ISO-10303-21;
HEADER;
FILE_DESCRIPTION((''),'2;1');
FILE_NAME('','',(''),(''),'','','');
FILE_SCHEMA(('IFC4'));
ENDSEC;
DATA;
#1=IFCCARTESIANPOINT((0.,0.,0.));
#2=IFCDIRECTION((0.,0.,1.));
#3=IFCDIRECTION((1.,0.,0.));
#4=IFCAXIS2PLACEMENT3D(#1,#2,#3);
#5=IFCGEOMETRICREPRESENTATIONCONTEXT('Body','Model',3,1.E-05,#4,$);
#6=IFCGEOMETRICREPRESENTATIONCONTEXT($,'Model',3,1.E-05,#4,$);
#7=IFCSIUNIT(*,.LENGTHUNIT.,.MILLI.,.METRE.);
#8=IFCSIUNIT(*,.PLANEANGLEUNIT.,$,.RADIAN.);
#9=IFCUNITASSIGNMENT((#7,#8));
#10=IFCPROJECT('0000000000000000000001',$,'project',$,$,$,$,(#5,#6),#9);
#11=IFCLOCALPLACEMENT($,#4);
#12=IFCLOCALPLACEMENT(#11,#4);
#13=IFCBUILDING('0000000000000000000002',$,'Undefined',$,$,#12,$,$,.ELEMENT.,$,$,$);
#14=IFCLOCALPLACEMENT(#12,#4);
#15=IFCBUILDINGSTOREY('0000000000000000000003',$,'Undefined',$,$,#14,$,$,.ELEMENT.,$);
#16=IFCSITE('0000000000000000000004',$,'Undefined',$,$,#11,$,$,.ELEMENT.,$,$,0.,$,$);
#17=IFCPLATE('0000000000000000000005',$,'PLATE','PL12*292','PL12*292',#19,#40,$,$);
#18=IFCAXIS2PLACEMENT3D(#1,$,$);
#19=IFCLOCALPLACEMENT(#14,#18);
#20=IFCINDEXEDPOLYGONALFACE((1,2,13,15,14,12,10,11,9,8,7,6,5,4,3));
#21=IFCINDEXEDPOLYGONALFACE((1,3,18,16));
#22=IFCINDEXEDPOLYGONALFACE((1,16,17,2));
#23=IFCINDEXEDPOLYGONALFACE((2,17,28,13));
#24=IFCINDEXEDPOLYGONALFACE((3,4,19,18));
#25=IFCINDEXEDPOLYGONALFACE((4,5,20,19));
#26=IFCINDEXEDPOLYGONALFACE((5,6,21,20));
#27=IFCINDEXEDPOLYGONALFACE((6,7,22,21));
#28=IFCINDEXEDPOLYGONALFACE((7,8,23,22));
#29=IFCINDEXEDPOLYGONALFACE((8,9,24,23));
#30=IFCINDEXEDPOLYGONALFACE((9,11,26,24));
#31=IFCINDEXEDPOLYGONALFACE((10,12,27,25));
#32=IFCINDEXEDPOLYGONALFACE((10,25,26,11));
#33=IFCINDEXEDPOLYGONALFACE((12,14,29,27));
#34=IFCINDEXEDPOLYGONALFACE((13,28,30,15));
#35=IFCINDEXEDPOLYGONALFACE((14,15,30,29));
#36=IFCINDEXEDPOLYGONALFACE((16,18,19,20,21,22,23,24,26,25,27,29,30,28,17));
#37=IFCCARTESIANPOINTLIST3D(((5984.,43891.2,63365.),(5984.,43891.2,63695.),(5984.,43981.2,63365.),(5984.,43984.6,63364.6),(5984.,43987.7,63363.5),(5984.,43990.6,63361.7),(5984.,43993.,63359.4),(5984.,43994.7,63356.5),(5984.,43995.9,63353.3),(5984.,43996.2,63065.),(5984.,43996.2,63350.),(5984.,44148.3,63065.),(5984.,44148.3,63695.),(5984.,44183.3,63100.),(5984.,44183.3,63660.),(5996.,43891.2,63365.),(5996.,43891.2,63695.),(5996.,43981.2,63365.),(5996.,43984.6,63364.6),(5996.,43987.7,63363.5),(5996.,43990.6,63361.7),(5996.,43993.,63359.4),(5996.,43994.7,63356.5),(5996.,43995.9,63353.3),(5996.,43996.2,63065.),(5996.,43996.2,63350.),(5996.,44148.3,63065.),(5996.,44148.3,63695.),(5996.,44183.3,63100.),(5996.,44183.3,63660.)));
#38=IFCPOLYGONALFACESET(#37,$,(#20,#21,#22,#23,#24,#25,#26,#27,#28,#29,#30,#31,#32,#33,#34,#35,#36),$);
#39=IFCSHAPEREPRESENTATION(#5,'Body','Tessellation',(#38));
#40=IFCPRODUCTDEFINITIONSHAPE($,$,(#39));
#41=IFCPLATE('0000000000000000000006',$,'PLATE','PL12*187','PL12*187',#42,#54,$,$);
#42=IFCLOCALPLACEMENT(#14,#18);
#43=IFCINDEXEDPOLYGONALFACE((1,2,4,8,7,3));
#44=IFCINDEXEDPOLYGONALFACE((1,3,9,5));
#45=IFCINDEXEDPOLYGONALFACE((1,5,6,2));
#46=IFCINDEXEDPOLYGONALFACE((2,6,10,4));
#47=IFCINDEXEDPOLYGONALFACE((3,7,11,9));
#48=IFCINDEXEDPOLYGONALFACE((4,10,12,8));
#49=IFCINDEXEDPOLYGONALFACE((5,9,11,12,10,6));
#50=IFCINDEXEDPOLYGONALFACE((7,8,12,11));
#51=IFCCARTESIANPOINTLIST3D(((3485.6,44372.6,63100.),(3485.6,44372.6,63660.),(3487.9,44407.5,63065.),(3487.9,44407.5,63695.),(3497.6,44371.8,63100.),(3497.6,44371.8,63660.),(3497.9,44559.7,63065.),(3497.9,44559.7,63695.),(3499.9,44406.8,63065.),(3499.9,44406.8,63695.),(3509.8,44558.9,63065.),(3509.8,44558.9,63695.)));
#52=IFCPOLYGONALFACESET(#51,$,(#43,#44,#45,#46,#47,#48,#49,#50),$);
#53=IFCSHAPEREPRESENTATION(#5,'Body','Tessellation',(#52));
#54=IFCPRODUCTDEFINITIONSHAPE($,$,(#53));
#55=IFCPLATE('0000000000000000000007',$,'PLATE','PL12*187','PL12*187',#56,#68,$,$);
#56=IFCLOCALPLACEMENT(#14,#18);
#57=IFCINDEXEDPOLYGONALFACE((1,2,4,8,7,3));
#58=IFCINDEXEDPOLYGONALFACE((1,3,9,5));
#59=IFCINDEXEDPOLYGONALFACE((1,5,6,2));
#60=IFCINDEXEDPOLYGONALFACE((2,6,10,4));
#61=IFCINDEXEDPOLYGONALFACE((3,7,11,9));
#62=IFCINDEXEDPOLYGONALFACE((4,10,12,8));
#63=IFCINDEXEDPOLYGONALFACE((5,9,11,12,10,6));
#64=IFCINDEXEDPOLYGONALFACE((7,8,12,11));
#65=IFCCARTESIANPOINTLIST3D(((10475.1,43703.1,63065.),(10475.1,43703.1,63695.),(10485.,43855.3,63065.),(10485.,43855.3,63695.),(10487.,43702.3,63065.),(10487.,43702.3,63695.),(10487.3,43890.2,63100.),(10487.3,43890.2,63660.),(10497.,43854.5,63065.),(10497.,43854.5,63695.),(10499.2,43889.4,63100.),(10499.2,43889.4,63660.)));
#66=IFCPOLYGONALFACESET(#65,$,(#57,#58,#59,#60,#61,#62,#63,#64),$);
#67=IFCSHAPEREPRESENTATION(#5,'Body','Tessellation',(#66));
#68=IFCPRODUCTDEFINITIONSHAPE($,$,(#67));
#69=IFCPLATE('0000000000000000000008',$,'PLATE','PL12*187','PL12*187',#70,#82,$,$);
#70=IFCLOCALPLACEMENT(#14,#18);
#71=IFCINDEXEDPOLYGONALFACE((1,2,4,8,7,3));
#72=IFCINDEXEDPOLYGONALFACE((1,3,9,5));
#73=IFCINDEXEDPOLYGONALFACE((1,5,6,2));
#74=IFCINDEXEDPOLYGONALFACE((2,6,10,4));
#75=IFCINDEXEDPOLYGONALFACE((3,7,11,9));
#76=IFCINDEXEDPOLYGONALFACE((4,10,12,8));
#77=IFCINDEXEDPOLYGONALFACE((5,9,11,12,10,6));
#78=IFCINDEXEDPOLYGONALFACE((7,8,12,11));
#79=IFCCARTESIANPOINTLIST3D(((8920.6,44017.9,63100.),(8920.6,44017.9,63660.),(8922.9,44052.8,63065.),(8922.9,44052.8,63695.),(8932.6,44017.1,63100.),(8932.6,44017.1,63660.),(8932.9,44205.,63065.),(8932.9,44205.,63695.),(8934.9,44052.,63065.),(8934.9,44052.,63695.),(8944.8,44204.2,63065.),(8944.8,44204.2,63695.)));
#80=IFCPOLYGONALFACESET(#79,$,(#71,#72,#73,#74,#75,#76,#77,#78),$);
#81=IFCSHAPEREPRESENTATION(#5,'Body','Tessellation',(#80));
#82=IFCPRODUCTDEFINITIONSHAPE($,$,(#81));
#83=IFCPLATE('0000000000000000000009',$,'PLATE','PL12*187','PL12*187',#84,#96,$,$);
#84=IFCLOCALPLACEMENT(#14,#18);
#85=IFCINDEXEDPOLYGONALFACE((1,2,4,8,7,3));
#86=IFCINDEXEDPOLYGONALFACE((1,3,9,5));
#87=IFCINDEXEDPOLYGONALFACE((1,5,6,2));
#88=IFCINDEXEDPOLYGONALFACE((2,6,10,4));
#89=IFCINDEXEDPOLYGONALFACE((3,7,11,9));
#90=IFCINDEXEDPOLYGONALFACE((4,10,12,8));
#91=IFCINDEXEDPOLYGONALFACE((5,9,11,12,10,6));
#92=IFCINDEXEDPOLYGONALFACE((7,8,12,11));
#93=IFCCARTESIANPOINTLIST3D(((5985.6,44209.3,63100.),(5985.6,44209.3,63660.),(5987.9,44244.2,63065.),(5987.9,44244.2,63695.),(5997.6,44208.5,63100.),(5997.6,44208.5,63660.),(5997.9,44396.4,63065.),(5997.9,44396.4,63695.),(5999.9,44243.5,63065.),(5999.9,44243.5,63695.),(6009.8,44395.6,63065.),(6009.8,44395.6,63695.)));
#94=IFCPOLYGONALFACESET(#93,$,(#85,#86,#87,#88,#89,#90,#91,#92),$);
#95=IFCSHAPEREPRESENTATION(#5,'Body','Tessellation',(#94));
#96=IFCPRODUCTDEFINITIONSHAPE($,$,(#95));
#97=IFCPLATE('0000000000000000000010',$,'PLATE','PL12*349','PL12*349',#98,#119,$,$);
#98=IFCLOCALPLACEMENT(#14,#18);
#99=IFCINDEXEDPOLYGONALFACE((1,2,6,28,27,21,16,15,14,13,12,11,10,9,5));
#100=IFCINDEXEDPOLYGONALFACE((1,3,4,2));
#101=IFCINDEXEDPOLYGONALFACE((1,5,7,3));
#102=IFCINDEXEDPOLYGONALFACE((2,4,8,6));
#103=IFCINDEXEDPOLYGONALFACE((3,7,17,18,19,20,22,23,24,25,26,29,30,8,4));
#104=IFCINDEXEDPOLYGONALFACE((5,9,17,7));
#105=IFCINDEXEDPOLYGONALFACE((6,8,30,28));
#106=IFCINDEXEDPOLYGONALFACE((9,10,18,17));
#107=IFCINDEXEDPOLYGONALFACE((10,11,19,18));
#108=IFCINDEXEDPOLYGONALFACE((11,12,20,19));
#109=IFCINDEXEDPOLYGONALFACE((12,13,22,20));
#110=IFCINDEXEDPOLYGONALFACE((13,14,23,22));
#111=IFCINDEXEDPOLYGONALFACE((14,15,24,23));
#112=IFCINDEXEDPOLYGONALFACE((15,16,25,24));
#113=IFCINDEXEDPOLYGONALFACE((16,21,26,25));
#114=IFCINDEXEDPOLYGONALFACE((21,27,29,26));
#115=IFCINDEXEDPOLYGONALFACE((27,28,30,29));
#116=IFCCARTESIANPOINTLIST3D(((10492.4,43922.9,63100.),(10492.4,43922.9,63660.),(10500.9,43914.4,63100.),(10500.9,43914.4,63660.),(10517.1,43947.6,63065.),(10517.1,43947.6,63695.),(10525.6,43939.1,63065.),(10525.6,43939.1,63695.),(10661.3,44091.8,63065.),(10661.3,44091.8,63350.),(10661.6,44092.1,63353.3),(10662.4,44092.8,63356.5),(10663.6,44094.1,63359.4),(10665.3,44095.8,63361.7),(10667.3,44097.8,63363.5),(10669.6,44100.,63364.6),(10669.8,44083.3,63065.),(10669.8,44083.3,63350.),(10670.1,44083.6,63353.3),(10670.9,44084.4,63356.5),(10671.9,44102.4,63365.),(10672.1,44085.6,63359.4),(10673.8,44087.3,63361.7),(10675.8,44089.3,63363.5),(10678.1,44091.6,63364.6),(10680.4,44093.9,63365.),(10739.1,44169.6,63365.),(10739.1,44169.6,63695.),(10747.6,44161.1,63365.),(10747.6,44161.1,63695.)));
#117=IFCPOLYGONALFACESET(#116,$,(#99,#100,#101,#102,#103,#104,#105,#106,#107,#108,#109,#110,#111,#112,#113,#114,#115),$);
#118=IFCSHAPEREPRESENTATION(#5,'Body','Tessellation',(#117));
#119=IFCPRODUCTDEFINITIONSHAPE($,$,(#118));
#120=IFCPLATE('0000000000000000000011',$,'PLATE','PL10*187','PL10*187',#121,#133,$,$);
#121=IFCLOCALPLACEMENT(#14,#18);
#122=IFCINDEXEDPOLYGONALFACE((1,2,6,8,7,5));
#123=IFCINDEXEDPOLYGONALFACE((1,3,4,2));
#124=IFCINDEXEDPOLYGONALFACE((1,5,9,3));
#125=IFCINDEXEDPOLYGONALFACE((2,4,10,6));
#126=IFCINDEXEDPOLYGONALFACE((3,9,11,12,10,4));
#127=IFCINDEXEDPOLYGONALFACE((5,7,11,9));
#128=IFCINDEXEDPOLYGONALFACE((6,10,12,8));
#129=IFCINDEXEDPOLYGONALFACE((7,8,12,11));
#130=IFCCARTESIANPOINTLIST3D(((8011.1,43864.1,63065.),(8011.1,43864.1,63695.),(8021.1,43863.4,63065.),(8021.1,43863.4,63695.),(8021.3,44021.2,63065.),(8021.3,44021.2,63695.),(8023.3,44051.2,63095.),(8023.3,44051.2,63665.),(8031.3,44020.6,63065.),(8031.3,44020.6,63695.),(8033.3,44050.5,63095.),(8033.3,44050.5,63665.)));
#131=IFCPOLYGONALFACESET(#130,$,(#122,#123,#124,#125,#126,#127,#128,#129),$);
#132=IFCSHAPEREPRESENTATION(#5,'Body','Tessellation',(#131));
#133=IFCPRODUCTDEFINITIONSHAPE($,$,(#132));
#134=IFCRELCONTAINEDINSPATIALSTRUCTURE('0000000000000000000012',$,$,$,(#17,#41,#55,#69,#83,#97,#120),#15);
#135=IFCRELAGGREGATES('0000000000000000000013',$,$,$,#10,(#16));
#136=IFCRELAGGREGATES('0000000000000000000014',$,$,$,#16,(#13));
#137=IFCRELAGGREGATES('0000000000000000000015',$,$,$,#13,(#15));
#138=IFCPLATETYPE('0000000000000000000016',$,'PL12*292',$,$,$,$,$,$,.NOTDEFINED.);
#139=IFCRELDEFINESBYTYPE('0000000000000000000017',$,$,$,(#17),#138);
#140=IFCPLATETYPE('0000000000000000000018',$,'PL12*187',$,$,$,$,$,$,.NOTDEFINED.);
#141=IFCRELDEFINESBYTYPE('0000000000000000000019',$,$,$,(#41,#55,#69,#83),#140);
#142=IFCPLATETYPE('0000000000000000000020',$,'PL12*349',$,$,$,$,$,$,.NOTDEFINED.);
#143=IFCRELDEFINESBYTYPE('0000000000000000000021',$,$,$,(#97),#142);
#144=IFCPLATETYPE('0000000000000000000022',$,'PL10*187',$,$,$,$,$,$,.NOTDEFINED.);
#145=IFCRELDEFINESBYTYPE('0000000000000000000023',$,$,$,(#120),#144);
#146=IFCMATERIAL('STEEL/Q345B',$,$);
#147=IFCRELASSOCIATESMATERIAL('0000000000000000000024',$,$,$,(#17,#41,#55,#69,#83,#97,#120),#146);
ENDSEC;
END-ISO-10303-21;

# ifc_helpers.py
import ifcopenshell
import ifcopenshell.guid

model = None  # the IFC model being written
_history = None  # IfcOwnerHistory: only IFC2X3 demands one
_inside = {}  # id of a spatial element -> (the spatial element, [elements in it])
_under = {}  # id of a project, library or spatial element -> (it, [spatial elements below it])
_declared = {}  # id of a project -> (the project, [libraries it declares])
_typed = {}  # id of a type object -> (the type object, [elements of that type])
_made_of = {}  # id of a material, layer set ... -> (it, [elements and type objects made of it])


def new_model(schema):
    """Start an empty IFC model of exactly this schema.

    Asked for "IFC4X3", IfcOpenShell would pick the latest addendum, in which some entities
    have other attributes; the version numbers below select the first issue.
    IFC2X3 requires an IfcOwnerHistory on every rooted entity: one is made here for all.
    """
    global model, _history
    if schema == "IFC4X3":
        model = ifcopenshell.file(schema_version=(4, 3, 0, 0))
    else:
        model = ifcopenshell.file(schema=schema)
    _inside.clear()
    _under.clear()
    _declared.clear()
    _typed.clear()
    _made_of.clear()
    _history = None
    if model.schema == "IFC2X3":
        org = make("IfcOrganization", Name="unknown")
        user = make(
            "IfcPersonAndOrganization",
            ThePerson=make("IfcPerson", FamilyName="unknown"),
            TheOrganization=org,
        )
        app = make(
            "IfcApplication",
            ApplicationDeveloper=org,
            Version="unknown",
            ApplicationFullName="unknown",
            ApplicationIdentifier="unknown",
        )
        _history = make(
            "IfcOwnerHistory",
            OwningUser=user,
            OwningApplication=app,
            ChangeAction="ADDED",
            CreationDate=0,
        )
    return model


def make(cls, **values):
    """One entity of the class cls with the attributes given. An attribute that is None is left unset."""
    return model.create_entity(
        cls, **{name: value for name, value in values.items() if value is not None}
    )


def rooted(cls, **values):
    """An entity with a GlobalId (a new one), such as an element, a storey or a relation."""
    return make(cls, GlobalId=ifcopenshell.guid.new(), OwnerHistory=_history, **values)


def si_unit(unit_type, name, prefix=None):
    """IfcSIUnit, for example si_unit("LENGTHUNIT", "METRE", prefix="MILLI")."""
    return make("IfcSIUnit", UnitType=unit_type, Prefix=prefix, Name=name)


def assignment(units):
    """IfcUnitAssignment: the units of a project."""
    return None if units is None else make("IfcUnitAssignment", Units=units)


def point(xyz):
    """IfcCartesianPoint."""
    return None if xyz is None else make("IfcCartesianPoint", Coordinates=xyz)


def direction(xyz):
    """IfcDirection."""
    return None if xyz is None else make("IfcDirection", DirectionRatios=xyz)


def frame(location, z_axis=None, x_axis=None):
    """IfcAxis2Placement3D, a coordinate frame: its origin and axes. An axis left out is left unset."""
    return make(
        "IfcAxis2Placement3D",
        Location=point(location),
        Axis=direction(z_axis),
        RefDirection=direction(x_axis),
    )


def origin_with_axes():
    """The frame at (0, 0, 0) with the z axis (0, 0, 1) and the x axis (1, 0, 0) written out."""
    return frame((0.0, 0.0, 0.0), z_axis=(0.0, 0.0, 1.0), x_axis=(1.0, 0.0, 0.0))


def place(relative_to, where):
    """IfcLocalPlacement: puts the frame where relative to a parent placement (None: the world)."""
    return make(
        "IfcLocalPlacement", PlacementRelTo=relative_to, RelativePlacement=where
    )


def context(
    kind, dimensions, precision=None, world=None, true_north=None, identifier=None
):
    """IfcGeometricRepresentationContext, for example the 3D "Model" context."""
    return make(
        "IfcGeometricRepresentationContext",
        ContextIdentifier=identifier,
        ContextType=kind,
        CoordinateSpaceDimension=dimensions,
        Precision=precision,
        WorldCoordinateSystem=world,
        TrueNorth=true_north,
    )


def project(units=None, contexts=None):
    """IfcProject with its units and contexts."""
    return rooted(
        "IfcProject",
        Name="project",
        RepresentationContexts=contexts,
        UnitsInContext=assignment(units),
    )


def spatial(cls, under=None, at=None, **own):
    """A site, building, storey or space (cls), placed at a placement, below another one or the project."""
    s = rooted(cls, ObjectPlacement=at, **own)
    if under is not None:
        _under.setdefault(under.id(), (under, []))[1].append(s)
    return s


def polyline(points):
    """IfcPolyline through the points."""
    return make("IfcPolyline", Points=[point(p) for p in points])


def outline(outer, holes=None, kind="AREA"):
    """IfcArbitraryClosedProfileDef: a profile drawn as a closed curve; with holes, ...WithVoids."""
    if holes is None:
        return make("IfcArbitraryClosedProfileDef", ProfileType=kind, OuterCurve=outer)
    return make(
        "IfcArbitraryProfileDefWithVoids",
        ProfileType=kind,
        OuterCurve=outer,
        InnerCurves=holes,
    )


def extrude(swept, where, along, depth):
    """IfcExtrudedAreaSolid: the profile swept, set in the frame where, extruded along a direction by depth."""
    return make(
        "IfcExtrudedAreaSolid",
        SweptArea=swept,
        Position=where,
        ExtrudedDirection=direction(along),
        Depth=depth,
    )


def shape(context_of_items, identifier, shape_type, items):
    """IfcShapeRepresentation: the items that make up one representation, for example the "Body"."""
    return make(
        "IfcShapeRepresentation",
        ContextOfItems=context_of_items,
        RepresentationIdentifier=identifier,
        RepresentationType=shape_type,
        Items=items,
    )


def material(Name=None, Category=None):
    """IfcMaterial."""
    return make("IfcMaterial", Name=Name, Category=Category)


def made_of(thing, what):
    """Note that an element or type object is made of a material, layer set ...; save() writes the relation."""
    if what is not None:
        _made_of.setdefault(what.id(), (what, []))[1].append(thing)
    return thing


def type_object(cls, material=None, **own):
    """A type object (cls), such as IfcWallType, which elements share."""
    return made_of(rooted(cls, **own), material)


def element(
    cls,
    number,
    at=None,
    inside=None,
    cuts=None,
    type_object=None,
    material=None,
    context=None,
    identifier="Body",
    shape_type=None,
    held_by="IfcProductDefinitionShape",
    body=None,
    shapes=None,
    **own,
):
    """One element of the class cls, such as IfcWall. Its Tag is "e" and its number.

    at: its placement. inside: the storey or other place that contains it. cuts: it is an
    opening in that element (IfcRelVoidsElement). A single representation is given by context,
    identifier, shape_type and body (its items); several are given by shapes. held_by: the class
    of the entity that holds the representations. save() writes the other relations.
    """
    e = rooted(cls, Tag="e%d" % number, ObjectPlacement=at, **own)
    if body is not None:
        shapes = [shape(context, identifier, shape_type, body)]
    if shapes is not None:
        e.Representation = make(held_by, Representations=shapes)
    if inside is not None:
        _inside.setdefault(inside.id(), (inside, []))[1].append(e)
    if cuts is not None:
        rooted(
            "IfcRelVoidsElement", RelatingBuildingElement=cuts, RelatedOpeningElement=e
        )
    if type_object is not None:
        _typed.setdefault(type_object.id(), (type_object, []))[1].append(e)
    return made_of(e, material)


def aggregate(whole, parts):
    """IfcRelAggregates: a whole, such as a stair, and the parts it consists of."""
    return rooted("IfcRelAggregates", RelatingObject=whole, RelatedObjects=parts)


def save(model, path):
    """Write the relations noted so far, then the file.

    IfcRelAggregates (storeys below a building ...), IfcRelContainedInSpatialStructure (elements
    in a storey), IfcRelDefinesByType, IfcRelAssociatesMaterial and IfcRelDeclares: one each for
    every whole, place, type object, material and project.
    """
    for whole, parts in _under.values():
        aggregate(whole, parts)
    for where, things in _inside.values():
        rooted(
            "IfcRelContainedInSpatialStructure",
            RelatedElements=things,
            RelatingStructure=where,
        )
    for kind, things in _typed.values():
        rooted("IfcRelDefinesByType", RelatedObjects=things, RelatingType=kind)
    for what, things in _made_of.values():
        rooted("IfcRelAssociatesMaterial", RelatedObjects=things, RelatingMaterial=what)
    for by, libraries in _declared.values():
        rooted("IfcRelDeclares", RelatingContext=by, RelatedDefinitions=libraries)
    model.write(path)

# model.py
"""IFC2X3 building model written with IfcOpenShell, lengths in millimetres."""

from ifc_helpers import new_model, si_unit, frame, origin_with_axes, place, context, project, spatial, polyline, outline, extrude, material, type_object, element, save


model = new_model("IFC2X3")

# Units and contexts
model_context_1 = context("Model", 3, precision=1e-05, world=origin_with_axes(), identifier="Body")
model_context_2 = context("Model", 3, precision=1e-05, world=origin_with_axes())
ifc_project = project(units=[si_unit("LENGTHUNIT", "METRE", prefix="MILLI"), si_unit("PLANEANGLEUNIT", "RADIAN")], contexts=[model_context_1, model_context_2])

# Site, building, storey
site_placement = place(None, origin_with_axes())
site = spatial("IfcSite", under=ifc_project, at=site_placement, Name="Undefined", CompositionType="ELEMENT", RefElevation=0.0)
building_placement = place(site_placement, origin_with_axes())
building = spatial("IfcBuilding", under=site, at=building_placement, Name="Undefined", CompositionType="ELEMENT")
storey_placement = place(building_placement, origin_with_axes())
storey = spatial("IfcBuildingStorey", under=building, at=storey_placement, Name="Undefined", CompositionType="ELEMENT")

# Shared definitions
ifc_material_1 = material(Name="STEEL/Q345B")

# Plates
plate_type_1 = type_object("IfcPlateType", Name="PL12*292", PredefinedType="NOTDEFINED")
for number, where, z_axis, x_axis, name in (
    (1, (5990.0, 43891.2, 63695.0), (-1.0, 0.0, 0.0), (0.0, 1.0, 0.0), "PLATE"),
):
    element("IfcPlate", number, at=place(storey_placement, frame(where, z_axis=z_axis, x_axis=x_axis)), inside=storey, type_object=plate_type_1, material=ifc_material_1, Name=name, Description="PL12*292", ObjectType="PL12*292", context=model_context_1, shape_type="SweptSolid", body=[
        extrude(outline(polyline([(0.0, 0.0), (257.2, 0.0), (292.2, 35.0), (292.2, 595.0), (257.2, 630.0), (105.1, 630.0), (105.1, 345.0), (104.7, 341.7), (103.6, 338.5), (101.8, 335.6), (99.4, 333.3), (96.6, 331.5), (93.4, 330.4), (90.1, 330.0), (0.0, 330.0), (0.0, 0.0)])), frame((0.0, 0.0, -6.0), z_axis=(0.0, 0.0, 1.0), x_axis=(1.0, 0.0, 0.0)), (0.0, 0.0, 1.0), 12.0),
    ])
plate_type_2 = type_object("IfcPlateType", Name="PL12*187", PredefinedType="NOTDEFINED")
for number, where, z_axis, x_axis, name in (
    (2, (3491.6, 44372.2, 63065.0), (0.997873, -0.065183, 0.0), (0.065184, 0.997873, 0.0), "PLATE"),
    (3, (10493.3, 43889.8, 63065.0), (-0.997873, 0.065184, 0.0), (-0.065183, -0.997873, 0.0), "PLATE"),
    (4, (8926.6, 44017.5, 63065.0), (0.997873, -0.065183, 0.0), (0.065184, 0.997873, 0.0), "PLATE"),
    (5, (5991.6, 44208.9, 63065.0), (0.997873, -0.065183, 0.0), (0.065184, 0.997873, 0.0), "PLATE"),
):
    element("IfcPlate", number, at=place(storey_placement, frame(where, z_axis=z_axis, x_axis=x_axis)), inside=storey, type_object=plate_type_2, material=ifc_material_1, Name=name, Description="PL12*187", ObjectType="PL12*187", context=model_context_1, shape_type="SweptSolid", body=[
        extrude(outline(polyline([(0.0, 35.0), (35.0, 0.0), (187.5, 0.0), (187.5, 630.0), (35.0, 630.0), (0.0, 595.0), (0.0, 35.0)])), frame((0.0, 0.0, -6.0), z_axis=(0.0, 0.0, 1.0), x_axis=(1.0, 0.0, 0.0)), (0.0, 0.0, 1.0), 12.0),
    ])
plate_type_3 = type_object("IfcPlateType", Name="PL12*349", PredefinedType="NOTDEFINED")
plate_1_placement = place(storey_placement, frame((10743.4, 44165.4, 63695.0), z_axis=(-0.707107, 0.707107, 0.0), x_axis=(0.0, 0.0, -1.0)))
element("IfcPlate", 6, at=plate_1_placement, inside=storey, type_object=plate_type_3, material=ifc_material_1, Name="PLATE", Description="PL12*349", ObjectType="PL12*349", context=model_context_1, shape_type="SweptSolid", body=[
    extrude(outline(polyline([(0.0, 0.0), (330.0, 0.0), (330.0, 95.0), (330.4, 98.4), (331.5, 101.5), (333.3, 104.4), (335.6, 106.8), (338.5, 108.5), (341.7, 109.7), (345.0, 110.0), (630.0, 110.0), (630.0, 313.9), (595.0, 348.9), (35.0, 348.9), (0.0, 313.9), (0.0, 0.0)])), frame((0.0, 0.0, -6.0), z_axis=(0.0, 0.0, 1.0), x_axis=(1.0, 0.0, 0.0)), (0.0, 0.0, 1.0), 12.0),
])
plate_type_4 = type_object("IfcPlateType", Name="PL10*187", PredefinedType="NOTDEFINED")
plate_2_placement = place(storey_placement, frame((8028.3, 44050.8, 63065.0), z_axis=(-0.997873, 0.065184, 0.0), x_axis=(-0.065183, -0.997873, 0.0)))
element("IfcPlate", 7, at=plate_2_placement, inside=storey, type_object=plate_type_4, material=ifc_material_1, Name="PLATE", Description="PL10*187", ObjectType="PL10*187", context=model_context_1, shape_type="SweptSolid", body=[
    extrude(outline(polyline([(0.0, 30.0), (30.0, 0.0), (187.5, 0.0), (187.5, 630.0), (30.0, 630.0), (0.0, 600.0), (0.0, 30.0)])), frame((0.0, 0.0, -5.0), z_axis=(0.0, 0.0, 1.0), x_axis=(1.0, 0.0, 0.0)), (0.0, 0.0, 1.0), 10.0),
])

save(model, "model.ifc")
